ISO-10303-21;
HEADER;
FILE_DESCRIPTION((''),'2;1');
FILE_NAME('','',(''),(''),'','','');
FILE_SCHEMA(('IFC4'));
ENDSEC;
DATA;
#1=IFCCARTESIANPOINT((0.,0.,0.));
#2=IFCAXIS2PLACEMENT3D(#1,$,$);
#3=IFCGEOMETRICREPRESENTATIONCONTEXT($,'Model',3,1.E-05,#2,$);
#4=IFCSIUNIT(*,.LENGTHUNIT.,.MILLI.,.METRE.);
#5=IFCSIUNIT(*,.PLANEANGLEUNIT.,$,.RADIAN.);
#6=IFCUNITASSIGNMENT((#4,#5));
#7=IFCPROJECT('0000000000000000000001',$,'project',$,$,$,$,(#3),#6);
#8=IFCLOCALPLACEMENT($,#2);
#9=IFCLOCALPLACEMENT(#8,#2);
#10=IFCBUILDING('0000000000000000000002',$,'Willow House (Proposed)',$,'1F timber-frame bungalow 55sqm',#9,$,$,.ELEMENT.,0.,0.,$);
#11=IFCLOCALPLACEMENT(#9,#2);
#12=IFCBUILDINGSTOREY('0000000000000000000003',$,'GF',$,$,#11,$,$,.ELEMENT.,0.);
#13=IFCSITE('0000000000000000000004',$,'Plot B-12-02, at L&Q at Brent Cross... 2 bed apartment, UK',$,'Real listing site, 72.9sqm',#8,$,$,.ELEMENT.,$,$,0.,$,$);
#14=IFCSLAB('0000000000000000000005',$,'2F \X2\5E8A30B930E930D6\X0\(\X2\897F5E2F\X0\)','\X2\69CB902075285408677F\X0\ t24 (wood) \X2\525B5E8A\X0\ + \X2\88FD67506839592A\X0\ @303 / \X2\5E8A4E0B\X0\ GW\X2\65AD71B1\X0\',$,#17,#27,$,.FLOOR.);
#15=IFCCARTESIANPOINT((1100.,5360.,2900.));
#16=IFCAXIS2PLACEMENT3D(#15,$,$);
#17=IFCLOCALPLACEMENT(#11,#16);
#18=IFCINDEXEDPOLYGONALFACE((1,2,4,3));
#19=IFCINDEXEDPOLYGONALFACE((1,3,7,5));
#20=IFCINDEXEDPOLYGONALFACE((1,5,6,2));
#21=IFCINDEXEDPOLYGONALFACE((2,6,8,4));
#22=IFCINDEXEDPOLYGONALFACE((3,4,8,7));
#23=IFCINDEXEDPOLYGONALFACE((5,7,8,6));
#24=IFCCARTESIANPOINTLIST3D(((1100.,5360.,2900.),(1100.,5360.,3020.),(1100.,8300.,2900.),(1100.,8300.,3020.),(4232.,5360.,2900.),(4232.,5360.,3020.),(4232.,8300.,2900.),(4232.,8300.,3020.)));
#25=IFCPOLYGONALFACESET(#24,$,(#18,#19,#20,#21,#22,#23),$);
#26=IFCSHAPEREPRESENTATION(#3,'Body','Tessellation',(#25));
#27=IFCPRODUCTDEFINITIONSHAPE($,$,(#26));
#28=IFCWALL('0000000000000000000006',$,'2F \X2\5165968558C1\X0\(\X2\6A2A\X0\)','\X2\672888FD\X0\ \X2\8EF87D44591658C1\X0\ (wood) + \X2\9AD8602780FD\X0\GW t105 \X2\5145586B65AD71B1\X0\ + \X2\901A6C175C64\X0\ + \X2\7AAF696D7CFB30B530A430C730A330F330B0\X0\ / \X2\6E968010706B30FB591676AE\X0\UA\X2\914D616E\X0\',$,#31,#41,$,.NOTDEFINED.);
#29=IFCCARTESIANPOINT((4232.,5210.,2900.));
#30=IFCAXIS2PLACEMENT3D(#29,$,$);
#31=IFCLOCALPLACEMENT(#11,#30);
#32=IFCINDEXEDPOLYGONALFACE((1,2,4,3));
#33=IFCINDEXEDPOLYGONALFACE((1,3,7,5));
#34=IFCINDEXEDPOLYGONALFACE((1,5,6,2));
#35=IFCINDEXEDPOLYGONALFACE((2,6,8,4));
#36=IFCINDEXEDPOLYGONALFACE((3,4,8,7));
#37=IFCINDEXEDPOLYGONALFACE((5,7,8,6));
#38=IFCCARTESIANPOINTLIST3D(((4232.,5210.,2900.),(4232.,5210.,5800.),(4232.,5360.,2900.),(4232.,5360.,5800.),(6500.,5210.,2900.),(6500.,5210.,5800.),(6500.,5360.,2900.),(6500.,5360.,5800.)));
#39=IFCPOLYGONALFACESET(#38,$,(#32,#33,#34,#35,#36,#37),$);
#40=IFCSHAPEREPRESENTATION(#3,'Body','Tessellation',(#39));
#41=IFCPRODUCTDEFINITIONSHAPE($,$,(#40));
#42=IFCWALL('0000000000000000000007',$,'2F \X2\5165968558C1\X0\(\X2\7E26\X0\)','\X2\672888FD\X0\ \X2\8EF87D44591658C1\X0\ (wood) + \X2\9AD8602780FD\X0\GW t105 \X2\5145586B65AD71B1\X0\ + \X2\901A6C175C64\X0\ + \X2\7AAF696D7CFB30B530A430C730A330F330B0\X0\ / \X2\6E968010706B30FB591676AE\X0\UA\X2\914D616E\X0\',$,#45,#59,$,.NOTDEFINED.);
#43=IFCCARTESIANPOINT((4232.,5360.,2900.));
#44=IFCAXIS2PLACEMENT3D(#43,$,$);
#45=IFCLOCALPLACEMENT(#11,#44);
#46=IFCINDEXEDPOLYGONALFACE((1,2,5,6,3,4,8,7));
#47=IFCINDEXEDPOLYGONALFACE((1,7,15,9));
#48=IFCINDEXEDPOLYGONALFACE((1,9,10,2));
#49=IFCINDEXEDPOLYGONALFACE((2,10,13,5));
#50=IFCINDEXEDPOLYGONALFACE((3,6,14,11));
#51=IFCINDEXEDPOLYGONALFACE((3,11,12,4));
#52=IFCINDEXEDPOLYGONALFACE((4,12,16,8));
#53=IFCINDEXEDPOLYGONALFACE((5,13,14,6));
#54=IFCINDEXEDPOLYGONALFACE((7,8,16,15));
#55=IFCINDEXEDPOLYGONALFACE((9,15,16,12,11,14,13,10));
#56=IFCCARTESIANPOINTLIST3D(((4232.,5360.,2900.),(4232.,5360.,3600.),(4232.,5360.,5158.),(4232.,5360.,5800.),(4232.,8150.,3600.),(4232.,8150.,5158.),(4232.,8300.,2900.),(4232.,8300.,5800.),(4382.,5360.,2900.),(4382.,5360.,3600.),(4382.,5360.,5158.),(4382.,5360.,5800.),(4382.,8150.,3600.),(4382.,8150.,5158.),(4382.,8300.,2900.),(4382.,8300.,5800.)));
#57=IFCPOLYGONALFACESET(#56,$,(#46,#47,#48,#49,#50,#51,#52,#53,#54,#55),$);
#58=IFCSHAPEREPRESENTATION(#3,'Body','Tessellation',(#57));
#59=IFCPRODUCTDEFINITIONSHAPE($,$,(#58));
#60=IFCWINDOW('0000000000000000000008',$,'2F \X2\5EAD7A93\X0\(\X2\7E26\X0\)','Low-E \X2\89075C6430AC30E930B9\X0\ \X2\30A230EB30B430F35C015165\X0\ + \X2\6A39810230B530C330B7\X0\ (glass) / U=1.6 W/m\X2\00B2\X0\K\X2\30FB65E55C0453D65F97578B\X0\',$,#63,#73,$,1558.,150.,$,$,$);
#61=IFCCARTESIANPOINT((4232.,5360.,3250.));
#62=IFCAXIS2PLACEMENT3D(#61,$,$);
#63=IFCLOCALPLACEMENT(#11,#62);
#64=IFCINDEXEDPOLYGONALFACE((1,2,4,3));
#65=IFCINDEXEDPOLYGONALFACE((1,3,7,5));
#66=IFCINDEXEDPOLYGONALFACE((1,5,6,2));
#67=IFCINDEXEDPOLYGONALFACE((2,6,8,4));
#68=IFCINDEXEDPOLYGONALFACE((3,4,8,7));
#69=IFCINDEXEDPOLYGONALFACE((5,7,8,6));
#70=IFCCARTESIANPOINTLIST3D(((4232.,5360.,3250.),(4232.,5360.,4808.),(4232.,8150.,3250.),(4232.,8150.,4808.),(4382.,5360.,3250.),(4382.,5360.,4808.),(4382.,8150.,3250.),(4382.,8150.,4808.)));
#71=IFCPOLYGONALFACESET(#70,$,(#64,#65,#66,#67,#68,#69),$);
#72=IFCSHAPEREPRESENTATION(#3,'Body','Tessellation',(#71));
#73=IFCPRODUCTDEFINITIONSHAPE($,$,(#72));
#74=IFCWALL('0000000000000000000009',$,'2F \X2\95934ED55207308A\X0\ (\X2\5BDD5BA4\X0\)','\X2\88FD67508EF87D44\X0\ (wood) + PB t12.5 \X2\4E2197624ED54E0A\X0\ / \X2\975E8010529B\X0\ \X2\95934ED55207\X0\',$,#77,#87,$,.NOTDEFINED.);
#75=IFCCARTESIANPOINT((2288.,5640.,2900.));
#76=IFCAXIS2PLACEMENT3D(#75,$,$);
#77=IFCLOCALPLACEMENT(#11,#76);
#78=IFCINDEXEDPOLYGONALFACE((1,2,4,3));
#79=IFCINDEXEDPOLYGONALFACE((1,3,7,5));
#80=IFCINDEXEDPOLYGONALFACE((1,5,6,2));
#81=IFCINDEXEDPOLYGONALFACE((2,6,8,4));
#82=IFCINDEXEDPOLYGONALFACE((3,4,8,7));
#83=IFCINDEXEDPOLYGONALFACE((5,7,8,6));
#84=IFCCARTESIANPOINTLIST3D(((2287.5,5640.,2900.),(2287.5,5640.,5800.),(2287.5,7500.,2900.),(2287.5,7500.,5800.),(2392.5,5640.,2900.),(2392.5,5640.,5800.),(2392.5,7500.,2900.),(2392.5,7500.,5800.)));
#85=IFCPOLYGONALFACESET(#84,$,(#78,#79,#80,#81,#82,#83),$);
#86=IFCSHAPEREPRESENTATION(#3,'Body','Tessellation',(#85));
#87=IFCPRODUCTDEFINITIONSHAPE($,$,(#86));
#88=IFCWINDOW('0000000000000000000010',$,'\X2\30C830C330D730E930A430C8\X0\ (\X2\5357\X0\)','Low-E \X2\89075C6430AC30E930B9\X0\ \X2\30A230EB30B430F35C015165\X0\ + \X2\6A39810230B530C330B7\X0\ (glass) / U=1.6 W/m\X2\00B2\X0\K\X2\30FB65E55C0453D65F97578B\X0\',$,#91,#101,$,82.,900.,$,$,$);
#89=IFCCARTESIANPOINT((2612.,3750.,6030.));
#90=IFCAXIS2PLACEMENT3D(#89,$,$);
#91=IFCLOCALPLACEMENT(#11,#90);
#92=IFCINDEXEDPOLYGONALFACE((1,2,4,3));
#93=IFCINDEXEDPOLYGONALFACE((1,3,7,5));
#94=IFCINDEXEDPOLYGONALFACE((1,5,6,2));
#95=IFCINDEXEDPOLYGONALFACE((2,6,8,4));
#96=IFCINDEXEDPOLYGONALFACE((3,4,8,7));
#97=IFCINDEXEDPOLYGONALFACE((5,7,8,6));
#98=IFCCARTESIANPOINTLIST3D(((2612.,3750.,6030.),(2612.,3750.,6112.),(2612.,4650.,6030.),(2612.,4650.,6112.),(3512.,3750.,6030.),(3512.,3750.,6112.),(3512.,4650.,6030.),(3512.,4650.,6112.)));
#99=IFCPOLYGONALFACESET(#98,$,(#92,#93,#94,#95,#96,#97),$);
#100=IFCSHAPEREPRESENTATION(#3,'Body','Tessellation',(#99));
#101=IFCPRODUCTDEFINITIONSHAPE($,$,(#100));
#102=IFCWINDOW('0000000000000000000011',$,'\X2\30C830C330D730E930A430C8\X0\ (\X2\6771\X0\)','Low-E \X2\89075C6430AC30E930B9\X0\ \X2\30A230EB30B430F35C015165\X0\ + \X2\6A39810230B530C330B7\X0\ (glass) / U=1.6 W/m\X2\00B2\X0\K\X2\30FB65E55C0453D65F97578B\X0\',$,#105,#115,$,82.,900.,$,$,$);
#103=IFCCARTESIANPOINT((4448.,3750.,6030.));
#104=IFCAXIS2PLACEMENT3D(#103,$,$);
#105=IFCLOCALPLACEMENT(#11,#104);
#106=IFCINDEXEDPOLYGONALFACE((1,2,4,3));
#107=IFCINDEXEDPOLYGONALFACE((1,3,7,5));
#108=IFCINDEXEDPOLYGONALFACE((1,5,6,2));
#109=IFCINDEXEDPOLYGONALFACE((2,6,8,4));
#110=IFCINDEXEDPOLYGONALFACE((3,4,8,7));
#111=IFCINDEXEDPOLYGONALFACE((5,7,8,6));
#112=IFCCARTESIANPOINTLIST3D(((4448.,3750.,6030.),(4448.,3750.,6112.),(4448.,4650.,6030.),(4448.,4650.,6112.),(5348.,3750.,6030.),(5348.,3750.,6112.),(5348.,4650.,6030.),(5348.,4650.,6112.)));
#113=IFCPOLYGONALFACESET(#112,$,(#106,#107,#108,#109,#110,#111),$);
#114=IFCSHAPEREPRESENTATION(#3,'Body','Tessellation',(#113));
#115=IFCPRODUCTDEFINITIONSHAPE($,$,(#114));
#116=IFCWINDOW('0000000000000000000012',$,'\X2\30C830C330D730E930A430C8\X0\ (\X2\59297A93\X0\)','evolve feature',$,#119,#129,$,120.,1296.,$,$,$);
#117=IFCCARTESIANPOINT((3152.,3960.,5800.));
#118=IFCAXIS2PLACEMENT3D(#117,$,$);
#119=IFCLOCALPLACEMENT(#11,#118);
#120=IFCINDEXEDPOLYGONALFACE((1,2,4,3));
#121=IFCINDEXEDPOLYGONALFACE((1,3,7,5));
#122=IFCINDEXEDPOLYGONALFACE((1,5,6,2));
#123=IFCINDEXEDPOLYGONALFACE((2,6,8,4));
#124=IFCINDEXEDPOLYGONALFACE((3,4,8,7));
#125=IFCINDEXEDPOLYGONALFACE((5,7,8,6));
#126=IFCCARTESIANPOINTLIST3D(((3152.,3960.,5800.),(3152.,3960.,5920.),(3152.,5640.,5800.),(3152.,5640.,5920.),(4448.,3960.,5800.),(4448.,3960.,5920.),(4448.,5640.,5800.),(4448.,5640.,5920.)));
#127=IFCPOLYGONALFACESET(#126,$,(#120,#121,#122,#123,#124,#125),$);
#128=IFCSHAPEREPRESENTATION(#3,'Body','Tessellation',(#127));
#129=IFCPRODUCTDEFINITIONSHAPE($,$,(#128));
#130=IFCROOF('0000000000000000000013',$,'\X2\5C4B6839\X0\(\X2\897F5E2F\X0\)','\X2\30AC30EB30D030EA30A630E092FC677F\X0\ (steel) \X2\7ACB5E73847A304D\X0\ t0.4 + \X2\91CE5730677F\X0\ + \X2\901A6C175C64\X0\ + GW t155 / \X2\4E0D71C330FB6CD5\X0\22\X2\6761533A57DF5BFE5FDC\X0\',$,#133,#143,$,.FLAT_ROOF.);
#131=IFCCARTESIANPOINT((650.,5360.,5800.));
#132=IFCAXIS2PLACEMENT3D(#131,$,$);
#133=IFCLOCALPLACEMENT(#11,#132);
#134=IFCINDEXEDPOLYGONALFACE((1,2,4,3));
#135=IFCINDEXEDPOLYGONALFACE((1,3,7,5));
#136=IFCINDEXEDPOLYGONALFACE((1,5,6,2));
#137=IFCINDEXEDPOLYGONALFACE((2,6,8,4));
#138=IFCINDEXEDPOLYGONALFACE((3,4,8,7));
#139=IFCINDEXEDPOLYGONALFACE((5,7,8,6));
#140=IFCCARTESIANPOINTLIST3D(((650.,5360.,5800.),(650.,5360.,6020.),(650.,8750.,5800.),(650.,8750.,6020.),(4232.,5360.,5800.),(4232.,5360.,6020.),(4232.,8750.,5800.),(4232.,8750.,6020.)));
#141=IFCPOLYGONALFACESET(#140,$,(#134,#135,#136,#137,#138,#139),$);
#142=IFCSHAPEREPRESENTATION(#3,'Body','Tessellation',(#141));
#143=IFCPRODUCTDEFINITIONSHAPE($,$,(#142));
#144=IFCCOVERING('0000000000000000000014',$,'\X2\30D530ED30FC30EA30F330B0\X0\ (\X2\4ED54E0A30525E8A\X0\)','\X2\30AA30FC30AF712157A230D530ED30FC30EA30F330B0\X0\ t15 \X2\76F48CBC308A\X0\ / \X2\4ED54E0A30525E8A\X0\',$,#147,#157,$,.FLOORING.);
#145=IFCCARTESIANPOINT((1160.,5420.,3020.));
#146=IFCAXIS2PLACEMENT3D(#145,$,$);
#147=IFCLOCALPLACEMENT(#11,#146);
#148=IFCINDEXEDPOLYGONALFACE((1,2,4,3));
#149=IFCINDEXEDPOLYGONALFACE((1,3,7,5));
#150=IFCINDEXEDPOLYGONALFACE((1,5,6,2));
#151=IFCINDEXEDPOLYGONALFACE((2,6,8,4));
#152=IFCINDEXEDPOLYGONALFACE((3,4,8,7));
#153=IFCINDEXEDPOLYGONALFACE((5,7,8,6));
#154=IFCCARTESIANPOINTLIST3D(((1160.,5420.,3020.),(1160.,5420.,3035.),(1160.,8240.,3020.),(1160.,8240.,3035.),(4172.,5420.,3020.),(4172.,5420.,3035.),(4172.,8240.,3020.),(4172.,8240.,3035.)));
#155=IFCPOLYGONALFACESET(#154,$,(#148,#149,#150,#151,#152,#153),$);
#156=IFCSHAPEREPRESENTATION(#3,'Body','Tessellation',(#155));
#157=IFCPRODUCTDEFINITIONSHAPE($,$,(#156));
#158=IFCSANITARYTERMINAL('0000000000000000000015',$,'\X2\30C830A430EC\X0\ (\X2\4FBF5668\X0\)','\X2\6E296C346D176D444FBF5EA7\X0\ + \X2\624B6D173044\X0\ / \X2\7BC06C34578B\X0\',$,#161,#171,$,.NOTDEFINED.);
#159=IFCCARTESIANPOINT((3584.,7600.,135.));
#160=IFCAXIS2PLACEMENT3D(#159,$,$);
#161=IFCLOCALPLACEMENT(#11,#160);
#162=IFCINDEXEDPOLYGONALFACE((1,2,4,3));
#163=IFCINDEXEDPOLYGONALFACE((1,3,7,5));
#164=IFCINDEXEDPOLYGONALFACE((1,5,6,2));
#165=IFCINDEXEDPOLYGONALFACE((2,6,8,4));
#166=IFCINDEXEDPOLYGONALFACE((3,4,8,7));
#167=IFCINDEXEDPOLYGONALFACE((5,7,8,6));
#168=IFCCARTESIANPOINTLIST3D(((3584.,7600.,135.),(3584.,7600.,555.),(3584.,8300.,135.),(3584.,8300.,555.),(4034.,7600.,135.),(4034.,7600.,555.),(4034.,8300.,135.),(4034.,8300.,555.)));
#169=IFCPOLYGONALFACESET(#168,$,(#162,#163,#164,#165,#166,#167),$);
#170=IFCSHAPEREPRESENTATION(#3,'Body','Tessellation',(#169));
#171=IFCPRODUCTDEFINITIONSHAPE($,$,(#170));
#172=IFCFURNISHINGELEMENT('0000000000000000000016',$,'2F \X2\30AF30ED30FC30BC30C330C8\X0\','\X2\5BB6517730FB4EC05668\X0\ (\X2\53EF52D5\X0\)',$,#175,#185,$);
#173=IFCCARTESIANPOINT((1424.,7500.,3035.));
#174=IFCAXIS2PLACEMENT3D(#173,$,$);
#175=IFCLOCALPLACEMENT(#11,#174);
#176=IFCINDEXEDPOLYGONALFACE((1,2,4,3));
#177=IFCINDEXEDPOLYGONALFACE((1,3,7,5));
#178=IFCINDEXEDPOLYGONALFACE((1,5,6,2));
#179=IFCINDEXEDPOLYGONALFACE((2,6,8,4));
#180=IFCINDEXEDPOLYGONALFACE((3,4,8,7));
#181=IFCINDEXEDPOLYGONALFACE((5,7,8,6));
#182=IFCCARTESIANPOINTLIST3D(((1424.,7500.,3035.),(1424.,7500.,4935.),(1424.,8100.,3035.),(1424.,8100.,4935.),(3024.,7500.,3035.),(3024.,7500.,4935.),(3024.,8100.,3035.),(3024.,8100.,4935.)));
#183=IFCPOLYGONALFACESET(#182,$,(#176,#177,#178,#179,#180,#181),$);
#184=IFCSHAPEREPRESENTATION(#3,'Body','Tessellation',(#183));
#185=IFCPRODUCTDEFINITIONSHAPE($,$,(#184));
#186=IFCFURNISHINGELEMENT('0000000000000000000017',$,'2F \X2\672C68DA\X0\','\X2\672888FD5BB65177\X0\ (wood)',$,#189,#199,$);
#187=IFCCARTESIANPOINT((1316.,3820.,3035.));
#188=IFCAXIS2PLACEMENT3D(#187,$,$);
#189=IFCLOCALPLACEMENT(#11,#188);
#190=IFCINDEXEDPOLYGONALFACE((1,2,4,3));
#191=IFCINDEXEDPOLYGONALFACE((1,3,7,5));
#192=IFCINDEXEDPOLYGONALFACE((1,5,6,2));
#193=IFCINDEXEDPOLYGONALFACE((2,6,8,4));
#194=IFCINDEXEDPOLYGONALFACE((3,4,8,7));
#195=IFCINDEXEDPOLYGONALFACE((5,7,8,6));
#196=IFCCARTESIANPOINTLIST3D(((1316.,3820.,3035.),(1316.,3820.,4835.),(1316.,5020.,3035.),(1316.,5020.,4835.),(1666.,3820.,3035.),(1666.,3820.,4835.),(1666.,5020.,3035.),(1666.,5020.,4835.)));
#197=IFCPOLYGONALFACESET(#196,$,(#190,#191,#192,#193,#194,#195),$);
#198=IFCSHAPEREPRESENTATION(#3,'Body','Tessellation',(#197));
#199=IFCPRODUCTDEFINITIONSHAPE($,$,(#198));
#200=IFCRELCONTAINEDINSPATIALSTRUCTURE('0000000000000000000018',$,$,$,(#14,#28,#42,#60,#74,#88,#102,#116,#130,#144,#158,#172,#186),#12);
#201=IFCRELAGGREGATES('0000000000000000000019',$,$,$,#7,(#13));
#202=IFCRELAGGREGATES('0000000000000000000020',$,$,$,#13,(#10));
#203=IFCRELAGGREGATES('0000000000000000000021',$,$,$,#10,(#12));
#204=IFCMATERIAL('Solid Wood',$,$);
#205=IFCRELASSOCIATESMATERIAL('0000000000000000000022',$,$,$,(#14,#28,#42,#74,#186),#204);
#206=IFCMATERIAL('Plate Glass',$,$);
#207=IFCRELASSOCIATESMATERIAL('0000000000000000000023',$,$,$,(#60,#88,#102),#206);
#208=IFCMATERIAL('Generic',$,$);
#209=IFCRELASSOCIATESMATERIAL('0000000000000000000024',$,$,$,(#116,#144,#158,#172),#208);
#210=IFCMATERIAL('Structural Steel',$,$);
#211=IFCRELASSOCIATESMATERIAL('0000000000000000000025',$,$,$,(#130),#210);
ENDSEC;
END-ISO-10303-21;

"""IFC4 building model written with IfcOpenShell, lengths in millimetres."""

from ifc_helpers import new_model, si_unit, frame, frame_2d, origin, place, context, project, spatial, rectangle, extrude, material, element, fill, save


model = new_model("IFC4")

# Units and contexts
model_context = context("Model", 3, precision=1e-05, world=origin())
ifc_project = project(units=[si_unit("LENGTHUNIT", "METRE", prefix="MILLI"), si_unit("PLANEANGLEUNIT", "RADIAN")], contexts=[model_context])

# Site, building, storey
site_placement = place(None, origin())
site = spatial("IfcSite", under=ifc_project, at=site_placement, Name="Plot B-12-02, at L&Q at Brent Cross... 2 bed apartment, UK", ObjectType="Real listing site, 72.9sqm", CompositionType="ELEMENT", RefElevation=0.0)
building_placement = place(site_placement, origin())
building = spatial("IfcBuilding", under=site, at=building_placement, Name="Willow House (Proposed)", ObjectType="1F timber-frame bungalow 55sqm", CompositionType="ELEMENT", ElevationOfRefHeight=0.0, ElevationOfTerrain=0.0)
storey_placement = place(building_placement, origin())
storey = spatial("IfcBuildingStorey", under=building, at=storey_placement, Name="GF", CompositionType="ELEMENT", Elevation=0.0)

# Slab
ifc_material_1 = material(Name="Solid Wood")
slab_placement = place(storey_placement, frame((1100.0, 5360.0, 2900.0)))
element("IfcSlab", 1, at=slab_placement, inside=storey, material=ifc_material_1, Name="2F 床スラブ(西帯)", Description="構造用合板 t24 (wood) 剛床 + 製材根太 @303 / 床下 GW断熱", PredefinedType="FLOOR", context=model_context, shape_type="SweptSolid", body=[
    extrude(rectangle(XDim=3132.0, YDim=2940.0, at=frame_2d((1566.0, 1470.0))), frame((1100.0, 5360.0, 2900.0)), (0.0, 0.0, 1.0), 120.0),
])

# Shared definitions
ifc_material_2 = material(Name="Plate Glass")

# Wall
wall_1_placement = place(storey_placement, frame((4232.0, 5210.0, 2900.0)))
element("IfcWall", 2, at=wall_1_placement, inside=storey, material=ifc_material_1, Name="2F 入隅壁(横)", Description="木製 軸組外壁 (wood) + 高性能GW t105 充填断熱 + 通気層 + 窯業系サイディング / 準耐火・外皮UA配慮", PredefinedType="NOTDEFINED", context=model_context, shape_type="SweptSolid", body=[
    extrude(rectangle(XDim=2268.0, YDim=150.0, at=frame_2d((1134.0, 75.0))), frame((4232.0, 5210.0, 2900.0)), (0.0, 0.0, 1.0), 2900.0),
])

# Wall, opening, window
wall_2_placement = place(storey_placement, frame((4232.0, 5360.0, 2900.0)))
wall_2 = element("IfcWall", 3, at=wall_2_placement, inside=storey, material=ifc_material_1, Name="2F 入隅壁(縦)", Description="木製 軸組外壁 (wood) + 高性能GW t105 充填断熱 + 通気層 + 窯業系サイディング / 準耐火・外皮UA配慮", PredefinedType="NOTDEFINED", context=model_context, shape_type="SweptSolid", body=[
    extrude(rectangle(XDim=150.0, YDim=2940.0, at=frame_2d((75.0, 1470.0))), frame((4232.0, 5360.0, 2900.0)), (0.0, 0.0, 1.0), 2900.0),
])
opening_1_placement = place(storey_placement, frame((4232.0, 5360.0, 3250.0)))
opening_1 = element("IfcOpeningElement", 4, at=opening_1_placement, cuts=wall_2, PredefinedType="NOTDEFINED", context=model_context, shape_type="SweptSolid", body=[
    extrude(rectangle(XDim=150.0, YDim=2790.0, at=frame_2d((75.0, 1395.0))), frame((4232.0, 5360.0, 3250.0)), (0.0, 0.0, 1.0), 1558.0),
])
window_1_placement = place(storey_placement, frame((4232.0, 5360.0, 3250.0)))
window_1 = element("IfcWindow", 5, at=window_1_placement, inside=storey, material=ifc_material_2, Name="2F 庭窓(縦)", Description="Low-E 複層ガラス アルゴン封入 + 樹脂サッシ (glass) / U=1.6 W/m²K・日射取得型", OverallHeight=1558.0, OverallWidth=150.0, context=model_context, shape_type="SweptSolid", body=[
    extrude(rectangle(XDim=150.0, YDim=2790.0, at=frame_2d((75.0, 1395.0))), frame((4232.0, 5360.0, 3250.0)), (0.0, 0.0, 1.0), 1558.0),
])
fill(opening_1, window_1)

# Wall
wall_3_placement = place(storey_placement, frame((2288.0, 5640.0, 2900.0)))
element("IfcWall", 6, at=wall_3_placement, inside=storey, material=ifc_material_1, Name="2F 間仕切り (寝室)", Description="製材軸組 (wood) + PB t12.5 両面仕上 / 非耐力 間仕切", PredefinedType="NOTDEFINED", context=model_context, shape_type="SweptSolid", body=[
    extrude(rectangle(XDim=105.0, YDim=1860.0, at=frame_2d((52.0, 930.0))), frame((2288.0, 5640.0, 2900.0)), (0.0, 0.0, 1.0), 2900.0),
])

# Windows
window_2_placement = place(storey_placement, frame((2612.0, 3750.0, 6030.0)))
element("IfcWindow", 7, at=window_2_placement, inside=storey, material=ifc_material_2, Name="トップライト (南)", Description="Low-E 複層ガラス アルゴン封入 + 樹脂サッシ (glass) / U=1.6 W/m²K・日射取得型", OverallHeight=82.0, OverallWidth=900.0, context=model_context, shape_type="SweptSolid", body=[
    extrude(rectangle(XDim=900.0, YDim=900.0, at=frame_2d((450.0, 450.0))), frame((2612.0, 3750.0, 6030.0)), (0.0, 0.0, 1.0), 82.0),
])
window_3_placement = place(storey_placement, frame((4448.0, 3750.0, 6030.0)))
element("IfcWindow", 8, at=window_3_placement, inside=storey, material=ifc_material_2, Name="トップライト (東)", Description="Low-E 複層ガラス アルゴン封入 + 樹脂サッシ (glass) / U=1.6 W/m²K・日射取得型", OverallHeight=82.0, OverallWidth=900.0, context=model_context, shape_type="SweptSolid", body=[
    extrude(rectangle(XDim=900.0, YDim=900.0, at=frame_2d((450.0, 450.0))), frame((4448.0, 3750.0, 6030.0)), (0.0, 0.0, 1.0), 82.0),
])
ifc_material_3 = material(Name="Generic")
window_4_placement = place(storey_placement, frame((3152.0, 3960.0, 5800.0)))
element("IfcWindow", 9, at=window_4_placement, inside=storey, material=ifc_material_3, Name="トップライト (天窓)", Description="evolve feature", OverallHeight=120.0, OverallWidth=1296.0, context=model_context, shape_type="SweptSolid", body=[
    extrude(rectangle(XDim=1296.0, YDim=1680.0, at=frame_2d((648.0, 840.0))), frame((3152.0, 3960.0, 5800.0)), (0.0, 0.0, 1.0), 120.0),
])

# Roof
ifc_material_4 = material(Name="Structural Steel")
for number, where, name in (
    (10, (650.0, 5360.0, 5800.0), "屋根(西帯)"),
):
    element("IfcRoof", number, at=place(storey_placement, frame(where)), inside=storey, material=ifc_material_4, Name=name, Description="ガルバリウム鋼板 (steel) 立平葺き t0.4 + 野地板 + 通気層 + GW t155 / 不燃・法22条区域対応", PredefinedType="FLAT_ROOF", context=model_context, shape_type="SweptSolid", body=[
        extrude(rectangle(XDim=3582.0, YDim=3390.0, at=frame_2d((1791.0, 1695.0))), frame((650.0, 5360.0, 5800.0)), (0.0, 0.0, 1.0), 220.0),
    ])

# Covering
covering_placement = place(storey_placement, frame((1160.0, 5420.0, 3020.0)))
element("IfcCovering", 11, at=covering_placement, inside=storey, material=ifc_material_3, Name="フローリング (仕上げ床)", Description="オーク無垢フローリング t15 直貼り / 仕上げ床", PredefinedType="FLOORING", context=model_context, shape_type="SweptSolid", body=[
    extrude(rectangle(XDim=3012.0, YDim=2820.0, at=frame_2d((1506.0, 1410.0))), frame((1160.0, 5420.0, 3020.0)), (0.0, 0.0, 1.0), 15.0),
])

# Sanitary terminal
sanitary_terminal_placement = place(storey_placement, frame((3584.0, 7600.0, 135.0)))
element("IfcSanitaryTerminal", 12, at=sanitary_terminal_placement, inside=storey, material=ifc_material_3, Name="トイレ (便器)", Description="温水洗浄便座 + 手洗い / 節水型", PredefinedType="NOTDEFINED", context=model_context, shape_type="SweptSolid", body=[
    extrude(rectangle(XDim=450.0, YDim=700.0, at=frame_2d((225.0, 350.0))), frame((3584.0, 7600.0, 135.0)), (0.0, 0.0, 1.0), 420.0),
])

# Furnishing elements
furnishing_1_placement = place(storey_placement, frame((1424.0, 7500.0, 3035.0)))
element("IfcFurnishingElement", 13, at=furnishing_1_placement, inside=storey, material=ifc_material_3, Name="2F クローゼット", Description="家具・什器 (可動)", context=model_context, shape_type="SweptSolid", body=[
    extrude(rectangle(XDim=1600.0, YDim=600.0, at=frame_2d((800.0, 300.0))), frame((1424.0, 7500.0, 3035.0)), (0.0, 0.0, 1.0), 1900.0),
])
furnishing_2_placement = place(storey_placement, frame((1316.0, 3820.0, 3035.0)))
element("IfcFurnishingElement", 14, at=furnishing_2_placement, inside=storey, material=ifc_material_1, Name="2F 本棚", Description="木製家具 (wood)", context=model_context, shape_type="SweptSolid", body=[
    extrude(rectangle(XDim=350.0, YDim=1200.0, at=frame_2d((175.0, 600.0))), frame((1316.0, 3820.0, 3035.0)), (0.0, 0.0, 1.0), 1800.0),
])

save(model, "model.ifc")
